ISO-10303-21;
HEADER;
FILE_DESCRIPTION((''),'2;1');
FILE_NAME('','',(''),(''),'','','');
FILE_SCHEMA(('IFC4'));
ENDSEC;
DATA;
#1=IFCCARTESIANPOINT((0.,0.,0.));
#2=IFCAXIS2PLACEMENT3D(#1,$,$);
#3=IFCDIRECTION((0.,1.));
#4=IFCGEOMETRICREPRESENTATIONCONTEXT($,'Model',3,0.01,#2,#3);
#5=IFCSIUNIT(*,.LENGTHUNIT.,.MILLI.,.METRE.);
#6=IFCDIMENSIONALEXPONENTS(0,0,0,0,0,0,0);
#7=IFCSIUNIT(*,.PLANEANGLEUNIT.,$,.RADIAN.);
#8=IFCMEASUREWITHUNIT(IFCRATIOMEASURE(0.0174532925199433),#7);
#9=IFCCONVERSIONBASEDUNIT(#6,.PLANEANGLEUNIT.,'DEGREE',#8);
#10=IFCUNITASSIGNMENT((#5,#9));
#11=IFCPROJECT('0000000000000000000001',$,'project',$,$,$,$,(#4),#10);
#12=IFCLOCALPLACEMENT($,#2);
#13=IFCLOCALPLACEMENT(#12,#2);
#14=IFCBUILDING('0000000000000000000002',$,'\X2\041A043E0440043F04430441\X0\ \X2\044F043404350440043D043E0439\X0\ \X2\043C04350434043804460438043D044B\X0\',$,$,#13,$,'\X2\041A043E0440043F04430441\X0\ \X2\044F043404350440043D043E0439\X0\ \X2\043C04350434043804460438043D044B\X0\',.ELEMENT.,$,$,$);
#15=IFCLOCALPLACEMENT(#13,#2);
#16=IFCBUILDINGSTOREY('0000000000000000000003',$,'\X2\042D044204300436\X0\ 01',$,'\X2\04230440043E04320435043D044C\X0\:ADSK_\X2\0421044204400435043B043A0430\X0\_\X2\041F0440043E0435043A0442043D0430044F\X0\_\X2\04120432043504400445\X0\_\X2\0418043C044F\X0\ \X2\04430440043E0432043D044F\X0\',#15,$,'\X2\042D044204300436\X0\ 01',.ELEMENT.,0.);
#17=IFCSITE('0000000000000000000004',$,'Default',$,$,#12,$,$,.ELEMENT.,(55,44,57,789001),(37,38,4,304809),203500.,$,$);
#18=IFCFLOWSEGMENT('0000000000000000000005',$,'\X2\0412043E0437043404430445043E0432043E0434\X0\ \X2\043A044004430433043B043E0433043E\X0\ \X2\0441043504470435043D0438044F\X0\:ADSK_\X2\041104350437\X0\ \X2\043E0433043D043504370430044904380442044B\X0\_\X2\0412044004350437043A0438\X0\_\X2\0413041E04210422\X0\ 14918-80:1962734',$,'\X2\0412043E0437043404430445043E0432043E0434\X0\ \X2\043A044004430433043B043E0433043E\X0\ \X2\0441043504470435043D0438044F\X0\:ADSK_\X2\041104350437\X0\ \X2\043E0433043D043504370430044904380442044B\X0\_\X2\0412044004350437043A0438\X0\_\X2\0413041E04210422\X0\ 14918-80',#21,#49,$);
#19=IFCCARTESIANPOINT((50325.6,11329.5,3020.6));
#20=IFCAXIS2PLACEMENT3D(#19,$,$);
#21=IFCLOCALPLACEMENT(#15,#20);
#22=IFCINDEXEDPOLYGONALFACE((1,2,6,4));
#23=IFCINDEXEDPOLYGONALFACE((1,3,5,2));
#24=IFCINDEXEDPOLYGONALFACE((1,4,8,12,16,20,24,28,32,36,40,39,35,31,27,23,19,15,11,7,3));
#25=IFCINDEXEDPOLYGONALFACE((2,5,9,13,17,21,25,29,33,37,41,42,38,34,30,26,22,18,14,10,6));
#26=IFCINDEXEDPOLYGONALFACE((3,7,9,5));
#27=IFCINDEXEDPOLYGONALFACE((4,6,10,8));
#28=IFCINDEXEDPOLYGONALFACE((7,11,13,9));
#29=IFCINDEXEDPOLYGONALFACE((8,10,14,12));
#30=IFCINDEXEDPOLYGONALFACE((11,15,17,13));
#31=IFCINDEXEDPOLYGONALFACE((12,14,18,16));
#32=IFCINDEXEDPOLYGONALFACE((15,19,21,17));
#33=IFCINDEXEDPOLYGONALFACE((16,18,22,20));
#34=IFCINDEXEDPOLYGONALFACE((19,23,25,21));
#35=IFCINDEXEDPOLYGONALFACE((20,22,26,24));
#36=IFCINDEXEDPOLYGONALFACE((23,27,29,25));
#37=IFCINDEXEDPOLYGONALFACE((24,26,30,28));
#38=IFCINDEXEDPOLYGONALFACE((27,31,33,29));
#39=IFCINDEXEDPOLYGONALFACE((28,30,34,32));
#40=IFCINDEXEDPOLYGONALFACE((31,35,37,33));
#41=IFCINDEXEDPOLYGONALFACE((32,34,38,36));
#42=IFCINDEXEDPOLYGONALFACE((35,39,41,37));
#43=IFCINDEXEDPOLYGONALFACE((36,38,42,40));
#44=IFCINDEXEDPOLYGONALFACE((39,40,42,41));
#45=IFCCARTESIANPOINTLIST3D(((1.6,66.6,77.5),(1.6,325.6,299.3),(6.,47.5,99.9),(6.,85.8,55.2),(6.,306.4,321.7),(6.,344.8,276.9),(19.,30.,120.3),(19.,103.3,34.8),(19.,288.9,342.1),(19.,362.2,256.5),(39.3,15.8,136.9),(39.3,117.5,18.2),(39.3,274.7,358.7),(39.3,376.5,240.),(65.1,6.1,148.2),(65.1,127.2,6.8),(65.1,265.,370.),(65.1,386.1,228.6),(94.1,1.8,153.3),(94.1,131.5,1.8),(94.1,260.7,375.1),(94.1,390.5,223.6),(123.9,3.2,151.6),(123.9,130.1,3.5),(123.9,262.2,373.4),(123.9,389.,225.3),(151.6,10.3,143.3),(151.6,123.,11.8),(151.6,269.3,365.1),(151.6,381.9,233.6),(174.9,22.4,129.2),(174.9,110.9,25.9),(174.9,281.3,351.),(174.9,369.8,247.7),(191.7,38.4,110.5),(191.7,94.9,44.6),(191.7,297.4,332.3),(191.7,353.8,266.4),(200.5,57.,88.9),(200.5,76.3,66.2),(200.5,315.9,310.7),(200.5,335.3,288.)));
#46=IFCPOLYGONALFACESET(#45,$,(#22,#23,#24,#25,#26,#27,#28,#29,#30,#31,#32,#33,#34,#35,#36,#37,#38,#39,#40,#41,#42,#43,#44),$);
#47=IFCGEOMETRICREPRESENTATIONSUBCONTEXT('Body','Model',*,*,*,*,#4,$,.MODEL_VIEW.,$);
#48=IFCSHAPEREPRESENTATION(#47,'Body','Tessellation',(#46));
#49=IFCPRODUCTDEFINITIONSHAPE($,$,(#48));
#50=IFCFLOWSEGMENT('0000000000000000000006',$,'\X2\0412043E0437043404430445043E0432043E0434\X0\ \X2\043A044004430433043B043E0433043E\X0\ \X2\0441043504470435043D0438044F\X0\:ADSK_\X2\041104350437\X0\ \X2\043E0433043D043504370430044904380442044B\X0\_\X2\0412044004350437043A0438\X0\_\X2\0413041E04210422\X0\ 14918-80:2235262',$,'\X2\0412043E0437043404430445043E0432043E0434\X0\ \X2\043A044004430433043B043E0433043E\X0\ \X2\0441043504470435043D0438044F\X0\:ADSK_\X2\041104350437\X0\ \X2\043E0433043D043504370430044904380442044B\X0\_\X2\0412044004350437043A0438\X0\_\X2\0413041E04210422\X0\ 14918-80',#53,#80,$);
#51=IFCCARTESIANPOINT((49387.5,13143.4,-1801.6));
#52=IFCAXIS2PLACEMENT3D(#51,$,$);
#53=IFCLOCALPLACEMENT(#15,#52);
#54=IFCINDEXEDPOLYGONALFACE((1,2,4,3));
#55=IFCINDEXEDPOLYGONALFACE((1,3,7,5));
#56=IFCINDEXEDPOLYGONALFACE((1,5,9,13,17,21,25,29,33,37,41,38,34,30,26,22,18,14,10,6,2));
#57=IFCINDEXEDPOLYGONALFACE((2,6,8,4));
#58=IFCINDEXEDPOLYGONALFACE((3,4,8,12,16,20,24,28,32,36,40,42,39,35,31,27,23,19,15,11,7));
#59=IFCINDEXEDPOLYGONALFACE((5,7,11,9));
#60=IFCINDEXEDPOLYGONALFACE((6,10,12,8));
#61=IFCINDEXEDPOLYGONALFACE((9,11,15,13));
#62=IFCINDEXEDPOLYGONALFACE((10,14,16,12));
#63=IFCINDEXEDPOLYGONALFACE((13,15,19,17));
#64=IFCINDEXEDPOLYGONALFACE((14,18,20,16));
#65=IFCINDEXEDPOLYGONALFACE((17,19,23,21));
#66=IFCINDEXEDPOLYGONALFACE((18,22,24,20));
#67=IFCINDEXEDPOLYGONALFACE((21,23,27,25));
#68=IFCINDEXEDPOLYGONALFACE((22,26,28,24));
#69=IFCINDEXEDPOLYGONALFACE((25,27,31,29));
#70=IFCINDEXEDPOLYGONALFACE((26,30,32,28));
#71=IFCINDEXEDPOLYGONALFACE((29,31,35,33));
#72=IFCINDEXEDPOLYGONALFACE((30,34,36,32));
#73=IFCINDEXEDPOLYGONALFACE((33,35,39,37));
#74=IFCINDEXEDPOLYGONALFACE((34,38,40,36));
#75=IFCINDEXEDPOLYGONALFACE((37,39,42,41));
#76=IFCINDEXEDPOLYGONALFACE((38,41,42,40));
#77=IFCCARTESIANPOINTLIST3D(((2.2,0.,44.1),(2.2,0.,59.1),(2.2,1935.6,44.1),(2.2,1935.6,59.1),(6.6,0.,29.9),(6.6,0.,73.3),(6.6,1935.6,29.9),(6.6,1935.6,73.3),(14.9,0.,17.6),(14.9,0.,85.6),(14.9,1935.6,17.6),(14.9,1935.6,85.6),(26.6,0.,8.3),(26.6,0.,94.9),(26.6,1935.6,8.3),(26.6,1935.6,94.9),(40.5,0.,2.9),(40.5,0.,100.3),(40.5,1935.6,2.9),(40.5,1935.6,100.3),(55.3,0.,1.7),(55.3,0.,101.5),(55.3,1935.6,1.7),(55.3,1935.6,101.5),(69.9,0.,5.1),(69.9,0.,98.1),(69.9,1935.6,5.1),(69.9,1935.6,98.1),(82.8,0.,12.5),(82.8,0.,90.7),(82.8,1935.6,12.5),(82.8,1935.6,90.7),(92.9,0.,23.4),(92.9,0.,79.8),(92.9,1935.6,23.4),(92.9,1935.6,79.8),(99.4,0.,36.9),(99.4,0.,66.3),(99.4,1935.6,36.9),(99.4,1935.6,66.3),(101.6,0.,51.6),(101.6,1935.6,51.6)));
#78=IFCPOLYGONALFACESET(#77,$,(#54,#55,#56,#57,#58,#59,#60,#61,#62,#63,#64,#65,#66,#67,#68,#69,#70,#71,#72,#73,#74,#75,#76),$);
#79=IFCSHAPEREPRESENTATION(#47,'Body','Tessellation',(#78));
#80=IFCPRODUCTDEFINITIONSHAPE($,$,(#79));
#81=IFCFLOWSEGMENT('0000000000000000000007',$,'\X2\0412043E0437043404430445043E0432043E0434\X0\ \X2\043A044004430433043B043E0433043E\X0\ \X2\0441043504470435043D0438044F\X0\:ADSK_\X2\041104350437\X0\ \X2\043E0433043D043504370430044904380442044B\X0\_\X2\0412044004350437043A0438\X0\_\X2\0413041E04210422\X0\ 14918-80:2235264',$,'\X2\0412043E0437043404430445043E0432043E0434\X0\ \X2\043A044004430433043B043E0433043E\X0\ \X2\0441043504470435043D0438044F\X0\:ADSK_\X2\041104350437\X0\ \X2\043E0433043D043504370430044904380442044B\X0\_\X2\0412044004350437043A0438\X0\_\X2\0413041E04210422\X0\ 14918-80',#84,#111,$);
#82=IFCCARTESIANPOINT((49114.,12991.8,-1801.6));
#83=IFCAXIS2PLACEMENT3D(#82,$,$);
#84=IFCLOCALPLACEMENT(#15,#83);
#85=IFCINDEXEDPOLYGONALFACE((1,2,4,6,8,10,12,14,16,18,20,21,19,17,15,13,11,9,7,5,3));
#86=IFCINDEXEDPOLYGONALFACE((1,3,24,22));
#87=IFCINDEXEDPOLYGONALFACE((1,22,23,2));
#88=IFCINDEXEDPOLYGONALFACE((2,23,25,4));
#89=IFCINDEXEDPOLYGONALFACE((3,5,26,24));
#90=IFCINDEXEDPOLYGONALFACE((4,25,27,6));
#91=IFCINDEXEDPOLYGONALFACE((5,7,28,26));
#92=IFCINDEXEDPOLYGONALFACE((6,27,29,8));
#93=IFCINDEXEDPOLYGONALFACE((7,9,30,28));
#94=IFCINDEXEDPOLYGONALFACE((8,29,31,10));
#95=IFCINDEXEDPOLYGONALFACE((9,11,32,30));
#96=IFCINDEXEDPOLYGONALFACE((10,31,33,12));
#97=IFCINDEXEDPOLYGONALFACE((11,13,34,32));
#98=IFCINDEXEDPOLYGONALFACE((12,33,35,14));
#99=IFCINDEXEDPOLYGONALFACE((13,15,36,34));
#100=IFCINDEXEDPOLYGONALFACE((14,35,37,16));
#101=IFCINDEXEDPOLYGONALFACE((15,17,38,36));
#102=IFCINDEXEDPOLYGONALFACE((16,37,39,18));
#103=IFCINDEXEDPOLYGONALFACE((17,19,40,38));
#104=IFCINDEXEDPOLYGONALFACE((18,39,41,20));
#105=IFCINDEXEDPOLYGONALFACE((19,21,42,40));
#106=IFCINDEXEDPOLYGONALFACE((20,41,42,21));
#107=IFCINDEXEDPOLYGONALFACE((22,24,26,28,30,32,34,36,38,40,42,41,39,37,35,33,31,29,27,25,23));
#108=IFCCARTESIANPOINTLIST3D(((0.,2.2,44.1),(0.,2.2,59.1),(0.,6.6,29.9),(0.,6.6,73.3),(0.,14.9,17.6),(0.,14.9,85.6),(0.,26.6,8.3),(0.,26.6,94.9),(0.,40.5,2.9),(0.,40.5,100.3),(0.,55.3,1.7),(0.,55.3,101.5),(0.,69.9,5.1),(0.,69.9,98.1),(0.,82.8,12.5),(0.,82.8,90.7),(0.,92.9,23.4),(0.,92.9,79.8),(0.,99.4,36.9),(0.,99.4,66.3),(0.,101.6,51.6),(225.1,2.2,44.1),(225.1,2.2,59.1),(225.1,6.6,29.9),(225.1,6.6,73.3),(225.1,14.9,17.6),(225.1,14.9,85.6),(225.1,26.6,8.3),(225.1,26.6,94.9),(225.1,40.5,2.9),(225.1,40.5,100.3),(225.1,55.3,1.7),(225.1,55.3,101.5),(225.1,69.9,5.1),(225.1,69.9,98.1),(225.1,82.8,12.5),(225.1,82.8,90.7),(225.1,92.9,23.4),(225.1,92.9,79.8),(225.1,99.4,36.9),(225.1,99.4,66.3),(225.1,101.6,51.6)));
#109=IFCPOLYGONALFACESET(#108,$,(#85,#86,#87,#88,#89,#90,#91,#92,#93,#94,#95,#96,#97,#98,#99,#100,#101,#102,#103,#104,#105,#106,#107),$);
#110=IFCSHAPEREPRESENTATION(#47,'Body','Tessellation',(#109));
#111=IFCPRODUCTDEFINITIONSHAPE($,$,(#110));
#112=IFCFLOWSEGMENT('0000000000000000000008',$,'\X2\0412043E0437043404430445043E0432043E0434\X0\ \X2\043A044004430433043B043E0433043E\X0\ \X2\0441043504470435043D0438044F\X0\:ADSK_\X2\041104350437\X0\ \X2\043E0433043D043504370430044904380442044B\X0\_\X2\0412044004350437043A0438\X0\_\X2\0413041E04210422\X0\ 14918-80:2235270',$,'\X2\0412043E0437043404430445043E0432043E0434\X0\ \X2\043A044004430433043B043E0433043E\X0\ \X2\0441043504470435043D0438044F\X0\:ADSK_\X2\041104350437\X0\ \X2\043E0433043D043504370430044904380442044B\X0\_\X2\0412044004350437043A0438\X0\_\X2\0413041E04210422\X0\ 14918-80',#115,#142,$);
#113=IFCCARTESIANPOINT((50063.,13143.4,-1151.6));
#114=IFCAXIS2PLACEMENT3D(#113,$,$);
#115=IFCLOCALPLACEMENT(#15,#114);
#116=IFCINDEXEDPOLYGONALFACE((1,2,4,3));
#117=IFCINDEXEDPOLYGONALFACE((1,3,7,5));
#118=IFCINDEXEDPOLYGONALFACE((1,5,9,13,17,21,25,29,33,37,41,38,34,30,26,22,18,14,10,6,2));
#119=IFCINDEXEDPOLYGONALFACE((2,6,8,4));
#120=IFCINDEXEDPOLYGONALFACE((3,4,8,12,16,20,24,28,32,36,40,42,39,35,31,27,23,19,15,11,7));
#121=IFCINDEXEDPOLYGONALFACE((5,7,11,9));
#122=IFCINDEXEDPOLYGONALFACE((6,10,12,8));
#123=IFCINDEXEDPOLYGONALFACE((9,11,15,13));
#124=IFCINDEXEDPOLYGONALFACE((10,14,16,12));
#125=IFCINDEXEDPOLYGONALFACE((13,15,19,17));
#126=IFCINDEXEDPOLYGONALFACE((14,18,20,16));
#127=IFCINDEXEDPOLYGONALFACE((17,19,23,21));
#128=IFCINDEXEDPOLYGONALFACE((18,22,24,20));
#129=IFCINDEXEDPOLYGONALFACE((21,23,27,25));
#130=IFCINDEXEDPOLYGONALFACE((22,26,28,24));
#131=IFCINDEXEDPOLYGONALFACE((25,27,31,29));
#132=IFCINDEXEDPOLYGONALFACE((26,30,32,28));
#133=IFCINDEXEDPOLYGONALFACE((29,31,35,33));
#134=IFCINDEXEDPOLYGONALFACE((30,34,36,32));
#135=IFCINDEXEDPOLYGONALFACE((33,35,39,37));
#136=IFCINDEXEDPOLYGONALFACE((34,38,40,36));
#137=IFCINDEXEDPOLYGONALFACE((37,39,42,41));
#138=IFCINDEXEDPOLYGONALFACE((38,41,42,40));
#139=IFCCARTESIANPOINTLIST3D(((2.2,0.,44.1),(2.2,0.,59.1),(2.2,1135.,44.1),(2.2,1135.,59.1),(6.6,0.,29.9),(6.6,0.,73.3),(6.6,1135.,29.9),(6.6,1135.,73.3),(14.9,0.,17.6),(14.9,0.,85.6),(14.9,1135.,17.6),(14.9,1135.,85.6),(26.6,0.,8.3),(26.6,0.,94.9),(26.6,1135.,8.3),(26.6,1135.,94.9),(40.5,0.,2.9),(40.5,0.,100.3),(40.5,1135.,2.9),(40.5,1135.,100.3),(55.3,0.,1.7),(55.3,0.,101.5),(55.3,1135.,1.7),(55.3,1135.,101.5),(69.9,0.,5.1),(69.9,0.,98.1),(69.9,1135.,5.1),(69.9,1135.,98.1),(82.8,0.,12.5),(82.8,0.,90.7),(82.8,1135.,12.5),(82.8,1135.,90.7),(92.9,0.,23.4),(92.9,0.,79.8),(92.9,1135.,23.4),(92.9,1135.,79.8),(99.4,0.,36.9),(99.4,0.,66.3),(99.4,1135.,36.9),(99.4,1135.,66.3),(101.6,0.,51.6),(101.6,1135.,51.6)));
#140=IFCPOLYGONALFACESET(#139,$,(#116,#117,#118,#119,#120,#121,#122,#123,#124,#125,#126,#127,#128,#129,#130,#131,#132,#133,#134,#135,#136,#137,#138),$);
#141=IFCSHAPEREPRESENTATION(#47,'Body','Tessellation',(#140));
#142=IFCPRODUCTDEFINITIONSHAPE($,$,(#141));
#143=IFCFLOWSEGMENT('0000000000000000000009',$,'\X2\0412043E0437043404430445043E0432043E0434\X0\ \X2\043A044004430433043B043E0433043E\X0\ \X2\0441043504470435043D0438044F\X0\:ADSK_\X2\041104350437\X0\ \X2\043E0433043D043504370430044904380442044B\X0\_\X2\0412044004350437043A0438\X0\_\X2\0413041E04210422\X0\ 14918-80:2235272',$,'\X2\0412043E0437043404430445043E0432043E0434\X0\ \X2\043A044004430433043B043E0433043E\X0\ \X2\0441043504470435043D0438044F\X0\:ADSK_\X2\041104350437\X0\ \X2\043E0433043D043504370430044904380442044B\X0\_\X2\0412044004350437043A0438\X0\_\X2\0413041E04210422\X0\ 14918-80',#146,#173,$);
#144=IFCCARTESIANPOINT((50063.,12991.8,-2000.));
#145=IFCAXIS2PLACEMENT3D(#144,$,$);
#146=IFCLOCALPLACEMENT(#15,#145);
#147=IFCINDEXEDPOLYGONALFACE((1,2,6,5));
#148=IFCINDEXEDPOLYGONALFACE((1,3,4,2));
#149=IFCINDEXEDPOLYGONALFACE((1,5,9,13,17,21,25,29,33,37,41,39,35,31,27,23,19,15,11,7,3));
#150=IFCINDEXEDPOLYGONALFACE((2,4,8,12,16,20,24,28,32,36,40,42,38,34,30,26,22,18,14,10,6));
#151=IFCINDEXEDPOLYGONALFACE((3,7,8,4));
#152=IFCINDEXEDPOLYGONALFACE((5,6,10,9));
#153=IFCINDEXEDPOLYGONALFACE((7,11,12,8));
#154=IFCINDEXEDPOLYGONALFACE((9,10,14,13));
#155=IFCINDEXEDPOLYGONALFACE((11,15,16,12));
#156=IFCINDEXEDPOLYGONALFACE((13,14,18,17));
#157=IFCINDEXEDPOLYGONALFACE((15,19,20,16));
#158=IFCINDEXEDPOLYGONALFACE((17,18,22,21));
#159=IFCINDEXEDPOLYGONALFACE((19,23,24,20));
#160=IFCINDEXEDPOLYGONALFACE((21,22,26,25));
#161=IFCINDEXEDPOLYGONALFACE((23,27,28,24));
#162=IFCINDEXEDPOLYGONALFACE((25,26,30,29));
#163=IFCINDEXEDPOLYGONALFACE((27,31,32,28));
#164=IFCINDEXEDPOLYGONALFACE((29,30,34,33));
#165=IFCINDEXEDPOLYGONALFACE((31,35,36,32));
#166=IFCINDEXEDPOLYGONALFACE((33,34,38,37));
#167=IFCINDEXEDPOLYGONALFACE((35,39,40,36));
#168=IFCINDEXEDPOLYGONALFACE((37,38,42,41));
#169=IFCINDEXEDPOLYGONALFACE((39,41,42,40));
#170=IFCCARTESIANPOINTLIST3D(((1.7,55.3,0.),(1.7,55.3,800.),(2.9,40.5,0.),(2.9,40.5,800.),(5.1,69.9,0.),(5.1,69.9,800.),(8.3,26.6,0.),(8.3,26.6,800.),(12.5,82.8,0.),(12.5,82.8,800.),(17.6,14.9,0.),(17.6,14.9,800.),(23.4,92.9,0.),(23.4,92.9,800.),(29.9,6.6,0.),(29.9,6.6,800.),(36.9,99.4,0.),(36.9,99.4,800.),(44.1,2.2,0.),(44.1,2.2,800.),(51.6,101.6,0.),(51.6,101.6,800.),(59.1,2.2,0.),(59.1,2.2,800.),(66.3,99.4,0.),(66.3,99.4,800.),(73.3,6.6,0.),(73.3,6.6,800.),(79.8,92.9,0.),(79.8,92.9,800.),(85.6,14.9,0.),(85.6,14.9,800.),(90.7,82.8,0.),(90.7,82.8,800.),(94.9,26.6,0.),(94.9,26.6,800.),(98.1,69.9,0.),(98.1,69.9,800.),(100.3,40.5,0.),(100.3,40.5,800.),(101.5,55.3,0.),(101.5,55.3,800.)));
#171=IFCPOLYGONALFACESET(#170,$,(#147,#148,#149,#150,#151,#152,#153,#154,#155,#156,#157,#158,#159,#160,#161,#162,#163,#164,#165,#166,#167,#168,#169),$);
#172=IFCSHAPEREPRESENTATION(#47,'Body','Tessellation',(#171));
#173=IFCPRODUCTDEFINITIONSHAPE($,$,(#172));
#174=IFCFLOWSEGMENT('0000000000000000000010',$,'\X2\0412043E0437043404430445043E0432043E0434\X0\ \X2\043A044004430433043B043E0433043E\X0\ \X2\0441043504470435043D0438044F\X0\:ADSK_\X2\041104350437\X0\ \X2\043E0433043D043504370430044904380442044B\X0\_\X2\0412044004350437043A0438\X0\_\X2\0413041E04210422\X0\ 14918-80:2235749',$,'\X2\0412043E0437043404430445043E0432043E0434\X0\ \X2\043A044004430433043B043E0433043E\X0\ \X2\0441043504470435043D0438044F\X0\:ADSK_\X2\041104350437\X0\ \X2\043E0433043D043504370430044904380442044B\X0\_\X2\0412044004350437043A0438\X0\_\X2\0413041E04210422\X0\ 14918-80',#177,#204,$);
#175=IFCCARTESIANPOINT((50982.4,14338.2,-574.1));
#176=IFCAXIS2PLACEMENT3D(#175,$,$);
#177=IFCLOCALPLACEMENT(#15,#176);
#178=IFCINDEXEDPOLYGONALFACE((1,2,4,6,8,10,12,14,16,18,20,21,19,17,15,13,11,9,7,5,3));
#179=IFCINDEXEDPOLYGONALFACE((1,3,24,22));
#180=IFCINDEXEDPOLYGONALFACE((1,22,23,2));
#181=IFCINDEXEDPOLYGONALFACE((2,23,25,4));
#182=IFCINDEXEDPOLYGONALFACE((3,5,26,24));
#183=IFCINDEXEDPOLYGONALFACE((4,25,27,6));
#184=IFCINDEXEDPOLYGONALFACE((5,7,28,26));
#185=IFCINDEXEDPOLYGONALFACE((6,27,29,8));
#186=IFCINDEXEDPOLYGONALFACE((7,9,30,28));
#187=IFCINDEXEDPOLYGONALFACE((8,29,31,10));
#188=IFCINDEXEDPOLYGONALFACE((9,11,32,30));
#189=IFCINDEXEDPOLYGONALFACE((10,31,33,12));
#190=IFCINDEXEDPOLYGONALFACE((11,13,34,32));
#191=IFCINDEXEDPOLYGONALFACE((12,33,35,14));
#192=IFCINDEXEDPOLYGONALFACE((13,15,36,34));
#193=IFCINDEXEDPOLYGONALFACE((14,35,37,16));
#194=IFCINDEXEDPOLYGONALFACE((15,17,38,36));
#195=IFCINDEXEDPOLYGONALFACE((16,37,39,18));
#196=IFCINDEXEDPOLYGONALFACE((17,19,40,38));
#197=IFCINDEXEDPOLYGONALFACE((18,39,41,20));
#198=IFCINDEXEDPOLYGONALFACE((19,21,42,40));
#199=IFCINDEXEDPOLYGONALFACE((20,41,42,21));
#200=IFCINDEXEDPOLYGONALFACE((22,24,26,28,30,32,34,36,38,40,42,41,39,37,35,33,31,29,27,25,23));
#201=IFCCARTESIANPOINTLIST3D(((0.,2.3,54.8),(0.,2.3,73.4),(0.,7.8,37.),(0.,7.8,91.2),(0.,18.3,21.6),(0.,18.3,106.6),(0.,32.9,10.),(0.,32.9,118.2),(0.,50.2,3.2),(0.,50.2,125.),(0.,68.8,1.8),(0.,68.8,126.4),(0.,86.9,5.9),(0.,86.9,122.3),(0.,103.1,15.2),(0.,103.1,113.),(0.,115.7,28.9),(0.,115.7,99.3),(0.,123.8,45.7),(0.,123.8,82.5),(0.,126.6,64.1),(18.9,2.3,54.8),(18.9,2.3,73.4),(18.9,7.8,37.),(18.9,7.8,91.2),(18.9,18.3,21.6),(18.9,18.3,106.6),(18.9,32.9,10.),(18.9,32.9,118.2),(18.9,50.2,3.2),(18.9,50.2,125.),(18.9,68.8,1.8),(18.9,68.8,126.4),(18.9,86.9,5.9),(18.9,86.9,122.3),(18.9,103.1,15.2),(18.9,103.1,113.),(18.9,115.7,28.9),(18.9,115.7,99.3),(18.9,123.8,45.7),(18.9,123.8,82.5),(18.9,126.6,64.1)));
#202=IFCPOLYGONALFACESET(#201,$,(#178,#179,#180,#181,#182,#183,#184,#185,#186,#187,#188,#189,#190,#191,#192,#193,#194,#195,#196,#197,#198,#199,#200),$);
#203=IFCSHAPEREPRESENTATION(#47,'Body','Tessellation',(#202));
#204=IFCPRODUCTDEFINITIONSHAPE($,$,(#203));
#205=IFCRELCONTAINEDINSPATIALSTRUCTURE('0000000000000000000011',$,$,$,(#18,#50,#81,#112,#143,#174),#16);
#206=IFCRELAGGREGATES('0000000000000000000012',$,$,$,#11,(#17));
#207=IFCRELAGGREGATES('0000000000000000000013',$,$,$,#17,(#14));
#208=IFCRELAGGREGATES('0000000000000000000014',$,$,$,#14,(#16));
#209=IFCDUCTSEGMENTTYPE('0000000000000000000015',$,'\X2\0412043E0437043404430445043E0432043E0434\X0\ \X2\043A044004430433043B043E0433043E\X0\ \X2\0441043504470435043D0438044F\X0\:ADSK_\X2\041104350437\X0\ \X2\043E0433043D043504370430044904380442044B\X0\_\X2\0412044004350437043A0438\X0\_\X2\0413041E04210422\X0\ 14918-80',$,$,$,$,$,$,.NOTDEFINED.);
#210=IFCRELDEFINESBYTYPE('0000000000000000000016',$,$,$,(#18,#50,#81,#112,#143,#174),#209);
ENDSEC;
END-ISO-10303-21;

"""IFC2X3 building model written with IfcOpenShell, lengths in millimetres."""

from ifc_helpers import new_model, entity, si_unit, converted_unit, direction, frame, origin, origin_2d_with_axis, place, context, subcontext, project, spatial, circle, extrude, type_object, element, save


model = new_model("IFC2X3")

# Units and contexts
model_context = context("Model", 3, precision=0.01, world=origin(), true_north=direction((0.0, 1.0)))
body_context = subcontext(model_context, "Body", "Model", "MODEL_VIEW")
ifc_project = project(units=[si_unit("LENGTHUNIT", "METRE", prefix="MILLI"), converted_unit("PLANEANGLEUNIT", "DEGREE", entity("IfcRatioMeasure", 0.0174532925199433), si_unit("PLANEANGLEUNIT", "RADIAN"), dimensions=[0, 0, 0, 0, 0, 0, 0])], contexts=[model_context])

# Site, building, storey
site_placement = place(None, origin())
site = spatial("IfcSite", under=ifc_project, at=site_placement, Name="Default", CompositionType="ELEMENT", RefLatitude=(55, 44, 57, 789001), RefLongitude=(37, 38, 4, 304809), RefElevation=203500.0)
building_placement = place(site_placement, origin())
building = spatial("IfcBuilding", under=site, at=building_placement, Name="Корпус ядерной медицины", LongName="Корпус ядерной медицины", CompositionType="ELEMENT")
storey_placement = place(building_placement, origin())
storey = spatial("IfcBuildingStorey", under=building, at=storey_placement, Name="Этаж 01", ObjectType="Уровень:ADSK_Стрелка_Проектная_Вверх_Имя уровня", LongName="Этаж 01", CompositionType="ELEMENT", Elevation=0.0)

# Flow segments
duct_segment_type_1 = type_object("IfcDuctSegmentType", Name="Воздуховод круглого сечения:ADSK_Без огнезащиты_Врезки_ГОСТ 14918-80", PredefinedType="NOTDEFINED")
flow_segment_1_placement = place(storey_placement, frame((50325.6, 11329.5, 3020.6)))
element("IfcFlowSegment", 1, at=flow_segment_1_placement, inside=storey, type_object=duct_segment_type_1, Name="Воздуховод круглого сечения:ADSK_Без огнезащиты_Врезки_ГОСТ 14918-80:1962734", ObjectType="Воздуховод круглого сечения:ADSK_Без огнезащиты_Врезки_ГОСТ 14918-80", context=body_context, shape_type="SweptSolid", body=[
    extrude(circle(Radius=100.0, at=origin_2d_with_axis()), frame((101.6, 66.7, 77.5), z_axis=(0.0, 0.759487, 0.650522), x_axis=(-1.0, 0.0, 0.0)), (0.0, 0.0, 1.0), 340.9),
])
flow_segment_2_placement = place(storey_placement, frame((49387.5, 13143.4, -1801.6)))
element("IfcFlowSegment", 2, at=flow_segment_2_placement, inside=storey, type_object=duct_segment_type_1, Name="Воздуховод круглого сечения:ADSK_Без огнезащиты_Врезки_ГОСТ 14918-80:2235262", ObjectType="Воздуховод круглого сечения:ADSK_Без огнезащиты_Врезки_ГОСТ 14918-80", context=body_context, shape_type="SweptSolid", body=[
    extrude(circle(Radius=50.0, at=origin_2d_with_axis()), frame((51.6, 0.0, 51.6), z_axis=(0.0, 1.0, 0.0), x_axis=(1.0, 0.0, 0.0)), (0.0, 0.0, 1.0), 1935.6),
])
flow_segment_3_placement = place(storey_placement, frame((49114.0, 12991.8, -1801.6)))
element("IfcFlowSegment", 3, at=flow_segment_3_placement, inside=storey, type_object=duct_segment_type_1, Name="Воздуховод круглого сечения:ADSK_Без огнезащиты_Врезки_ГОСТ 14918-80:2235264", ObjectType="Воздуховод круглого сечения:ADSK_Без огнезащиты_Врезки_ГОСТ 14918-80", context=body_context, shape_type="SweptSolid", body=[
    extrude(circle(Radius=50.0, at=origin_2d_with_axis()), frame((0.0, 51.6, 51.6), z_axis=(1.0, 0.0, 0.0), x_axis=(0.0, 1.0, 0.0)), (0.0, 0.0, 1.0), 225.1),
])
flow_segment_4_placement = place(storey_placement, frame((50063.0, 13143.4, -1151.6)))
element("IfcFlowSegment", 4, at=flow_segment_4_placement, inside=storey, type_object=duct_segment_type_1, Name="Воздуховод круглого сечения:ADSK_Без огнезащиты_Врезки_ГОСТ 14918-80:2235270", ObjectType="Воздуховод круглого сечения:ADSK_Без огнезащиты_Врезки_ГОСТ 14918-80", context=body_context, shape_type="SweptSolid", body=[
    extrude(circle(Radius=50.0, at=origin_2d_with_axis()), frame((51.6, 0.0, 51.6), z_axis=(0.0, 1.0, 0.0), x_axis=(1.0, 0.0, 0.0)), (0.0, 0.0, 1.0), 1135.0),
])
flow_segment_5_placement = place(storey_placement, frame((50063.0, 12991.8, -2000.0)))
element("IfcFlowSegment", 5, at=flow_segment_5_placement, inside=storey, type_object=duct_segment_type_1, Name="Воздуховод круглого сечения:ADSK_Без огнезащиты_Врезки_ГОСТ 14918-80:2235272", ObjectType="Воздуховод круглого сечения:ADSK_Без огнезащиты_Врезки_ГОСТ 14918-80", context=body_context, shape_type="SweptSolid", body=[
    extrude(circle(Radius=50.0, at=origin_2d_with_axis()), frame((51.6, 51.6, 0.0), z_axis=(0.0, 0.0, 1.0), x_axis=(0.0, 1.0, 0.0)), (0.0, 0.0, 1.0), 800.0),
])
flow_segment_6_placement = place(storey_placement, frame((50982.4, 14338.2, -574.1)))
element("IfcFlowSegment", 6, at=flow_segment_6_placement, inside=storey, type_object=duct_segment_type_1, Name="Воздуховод круглого сечения:ADSK_Без огнезащиты_Врезки_ГОСТ 14918-80:2235749", ObjectType="Воздуховод круглого сечения:ADSK_Без огнезащиты_Врезки_ГОСТ 14918-80", context=body_context, shape_type="SweptSolid", body=[
    extrude(circle(Radius=62.5, at=origin_2d_with_axis()), frame((0.0, 64.1, 64.1), z_axis=(1.0, 0.0, 0.0), x_axis=(0.0, 1.0, 0.0)), (0.0, 0.0, 1.0), 18.9),
])

save(model, "model.ifc")
